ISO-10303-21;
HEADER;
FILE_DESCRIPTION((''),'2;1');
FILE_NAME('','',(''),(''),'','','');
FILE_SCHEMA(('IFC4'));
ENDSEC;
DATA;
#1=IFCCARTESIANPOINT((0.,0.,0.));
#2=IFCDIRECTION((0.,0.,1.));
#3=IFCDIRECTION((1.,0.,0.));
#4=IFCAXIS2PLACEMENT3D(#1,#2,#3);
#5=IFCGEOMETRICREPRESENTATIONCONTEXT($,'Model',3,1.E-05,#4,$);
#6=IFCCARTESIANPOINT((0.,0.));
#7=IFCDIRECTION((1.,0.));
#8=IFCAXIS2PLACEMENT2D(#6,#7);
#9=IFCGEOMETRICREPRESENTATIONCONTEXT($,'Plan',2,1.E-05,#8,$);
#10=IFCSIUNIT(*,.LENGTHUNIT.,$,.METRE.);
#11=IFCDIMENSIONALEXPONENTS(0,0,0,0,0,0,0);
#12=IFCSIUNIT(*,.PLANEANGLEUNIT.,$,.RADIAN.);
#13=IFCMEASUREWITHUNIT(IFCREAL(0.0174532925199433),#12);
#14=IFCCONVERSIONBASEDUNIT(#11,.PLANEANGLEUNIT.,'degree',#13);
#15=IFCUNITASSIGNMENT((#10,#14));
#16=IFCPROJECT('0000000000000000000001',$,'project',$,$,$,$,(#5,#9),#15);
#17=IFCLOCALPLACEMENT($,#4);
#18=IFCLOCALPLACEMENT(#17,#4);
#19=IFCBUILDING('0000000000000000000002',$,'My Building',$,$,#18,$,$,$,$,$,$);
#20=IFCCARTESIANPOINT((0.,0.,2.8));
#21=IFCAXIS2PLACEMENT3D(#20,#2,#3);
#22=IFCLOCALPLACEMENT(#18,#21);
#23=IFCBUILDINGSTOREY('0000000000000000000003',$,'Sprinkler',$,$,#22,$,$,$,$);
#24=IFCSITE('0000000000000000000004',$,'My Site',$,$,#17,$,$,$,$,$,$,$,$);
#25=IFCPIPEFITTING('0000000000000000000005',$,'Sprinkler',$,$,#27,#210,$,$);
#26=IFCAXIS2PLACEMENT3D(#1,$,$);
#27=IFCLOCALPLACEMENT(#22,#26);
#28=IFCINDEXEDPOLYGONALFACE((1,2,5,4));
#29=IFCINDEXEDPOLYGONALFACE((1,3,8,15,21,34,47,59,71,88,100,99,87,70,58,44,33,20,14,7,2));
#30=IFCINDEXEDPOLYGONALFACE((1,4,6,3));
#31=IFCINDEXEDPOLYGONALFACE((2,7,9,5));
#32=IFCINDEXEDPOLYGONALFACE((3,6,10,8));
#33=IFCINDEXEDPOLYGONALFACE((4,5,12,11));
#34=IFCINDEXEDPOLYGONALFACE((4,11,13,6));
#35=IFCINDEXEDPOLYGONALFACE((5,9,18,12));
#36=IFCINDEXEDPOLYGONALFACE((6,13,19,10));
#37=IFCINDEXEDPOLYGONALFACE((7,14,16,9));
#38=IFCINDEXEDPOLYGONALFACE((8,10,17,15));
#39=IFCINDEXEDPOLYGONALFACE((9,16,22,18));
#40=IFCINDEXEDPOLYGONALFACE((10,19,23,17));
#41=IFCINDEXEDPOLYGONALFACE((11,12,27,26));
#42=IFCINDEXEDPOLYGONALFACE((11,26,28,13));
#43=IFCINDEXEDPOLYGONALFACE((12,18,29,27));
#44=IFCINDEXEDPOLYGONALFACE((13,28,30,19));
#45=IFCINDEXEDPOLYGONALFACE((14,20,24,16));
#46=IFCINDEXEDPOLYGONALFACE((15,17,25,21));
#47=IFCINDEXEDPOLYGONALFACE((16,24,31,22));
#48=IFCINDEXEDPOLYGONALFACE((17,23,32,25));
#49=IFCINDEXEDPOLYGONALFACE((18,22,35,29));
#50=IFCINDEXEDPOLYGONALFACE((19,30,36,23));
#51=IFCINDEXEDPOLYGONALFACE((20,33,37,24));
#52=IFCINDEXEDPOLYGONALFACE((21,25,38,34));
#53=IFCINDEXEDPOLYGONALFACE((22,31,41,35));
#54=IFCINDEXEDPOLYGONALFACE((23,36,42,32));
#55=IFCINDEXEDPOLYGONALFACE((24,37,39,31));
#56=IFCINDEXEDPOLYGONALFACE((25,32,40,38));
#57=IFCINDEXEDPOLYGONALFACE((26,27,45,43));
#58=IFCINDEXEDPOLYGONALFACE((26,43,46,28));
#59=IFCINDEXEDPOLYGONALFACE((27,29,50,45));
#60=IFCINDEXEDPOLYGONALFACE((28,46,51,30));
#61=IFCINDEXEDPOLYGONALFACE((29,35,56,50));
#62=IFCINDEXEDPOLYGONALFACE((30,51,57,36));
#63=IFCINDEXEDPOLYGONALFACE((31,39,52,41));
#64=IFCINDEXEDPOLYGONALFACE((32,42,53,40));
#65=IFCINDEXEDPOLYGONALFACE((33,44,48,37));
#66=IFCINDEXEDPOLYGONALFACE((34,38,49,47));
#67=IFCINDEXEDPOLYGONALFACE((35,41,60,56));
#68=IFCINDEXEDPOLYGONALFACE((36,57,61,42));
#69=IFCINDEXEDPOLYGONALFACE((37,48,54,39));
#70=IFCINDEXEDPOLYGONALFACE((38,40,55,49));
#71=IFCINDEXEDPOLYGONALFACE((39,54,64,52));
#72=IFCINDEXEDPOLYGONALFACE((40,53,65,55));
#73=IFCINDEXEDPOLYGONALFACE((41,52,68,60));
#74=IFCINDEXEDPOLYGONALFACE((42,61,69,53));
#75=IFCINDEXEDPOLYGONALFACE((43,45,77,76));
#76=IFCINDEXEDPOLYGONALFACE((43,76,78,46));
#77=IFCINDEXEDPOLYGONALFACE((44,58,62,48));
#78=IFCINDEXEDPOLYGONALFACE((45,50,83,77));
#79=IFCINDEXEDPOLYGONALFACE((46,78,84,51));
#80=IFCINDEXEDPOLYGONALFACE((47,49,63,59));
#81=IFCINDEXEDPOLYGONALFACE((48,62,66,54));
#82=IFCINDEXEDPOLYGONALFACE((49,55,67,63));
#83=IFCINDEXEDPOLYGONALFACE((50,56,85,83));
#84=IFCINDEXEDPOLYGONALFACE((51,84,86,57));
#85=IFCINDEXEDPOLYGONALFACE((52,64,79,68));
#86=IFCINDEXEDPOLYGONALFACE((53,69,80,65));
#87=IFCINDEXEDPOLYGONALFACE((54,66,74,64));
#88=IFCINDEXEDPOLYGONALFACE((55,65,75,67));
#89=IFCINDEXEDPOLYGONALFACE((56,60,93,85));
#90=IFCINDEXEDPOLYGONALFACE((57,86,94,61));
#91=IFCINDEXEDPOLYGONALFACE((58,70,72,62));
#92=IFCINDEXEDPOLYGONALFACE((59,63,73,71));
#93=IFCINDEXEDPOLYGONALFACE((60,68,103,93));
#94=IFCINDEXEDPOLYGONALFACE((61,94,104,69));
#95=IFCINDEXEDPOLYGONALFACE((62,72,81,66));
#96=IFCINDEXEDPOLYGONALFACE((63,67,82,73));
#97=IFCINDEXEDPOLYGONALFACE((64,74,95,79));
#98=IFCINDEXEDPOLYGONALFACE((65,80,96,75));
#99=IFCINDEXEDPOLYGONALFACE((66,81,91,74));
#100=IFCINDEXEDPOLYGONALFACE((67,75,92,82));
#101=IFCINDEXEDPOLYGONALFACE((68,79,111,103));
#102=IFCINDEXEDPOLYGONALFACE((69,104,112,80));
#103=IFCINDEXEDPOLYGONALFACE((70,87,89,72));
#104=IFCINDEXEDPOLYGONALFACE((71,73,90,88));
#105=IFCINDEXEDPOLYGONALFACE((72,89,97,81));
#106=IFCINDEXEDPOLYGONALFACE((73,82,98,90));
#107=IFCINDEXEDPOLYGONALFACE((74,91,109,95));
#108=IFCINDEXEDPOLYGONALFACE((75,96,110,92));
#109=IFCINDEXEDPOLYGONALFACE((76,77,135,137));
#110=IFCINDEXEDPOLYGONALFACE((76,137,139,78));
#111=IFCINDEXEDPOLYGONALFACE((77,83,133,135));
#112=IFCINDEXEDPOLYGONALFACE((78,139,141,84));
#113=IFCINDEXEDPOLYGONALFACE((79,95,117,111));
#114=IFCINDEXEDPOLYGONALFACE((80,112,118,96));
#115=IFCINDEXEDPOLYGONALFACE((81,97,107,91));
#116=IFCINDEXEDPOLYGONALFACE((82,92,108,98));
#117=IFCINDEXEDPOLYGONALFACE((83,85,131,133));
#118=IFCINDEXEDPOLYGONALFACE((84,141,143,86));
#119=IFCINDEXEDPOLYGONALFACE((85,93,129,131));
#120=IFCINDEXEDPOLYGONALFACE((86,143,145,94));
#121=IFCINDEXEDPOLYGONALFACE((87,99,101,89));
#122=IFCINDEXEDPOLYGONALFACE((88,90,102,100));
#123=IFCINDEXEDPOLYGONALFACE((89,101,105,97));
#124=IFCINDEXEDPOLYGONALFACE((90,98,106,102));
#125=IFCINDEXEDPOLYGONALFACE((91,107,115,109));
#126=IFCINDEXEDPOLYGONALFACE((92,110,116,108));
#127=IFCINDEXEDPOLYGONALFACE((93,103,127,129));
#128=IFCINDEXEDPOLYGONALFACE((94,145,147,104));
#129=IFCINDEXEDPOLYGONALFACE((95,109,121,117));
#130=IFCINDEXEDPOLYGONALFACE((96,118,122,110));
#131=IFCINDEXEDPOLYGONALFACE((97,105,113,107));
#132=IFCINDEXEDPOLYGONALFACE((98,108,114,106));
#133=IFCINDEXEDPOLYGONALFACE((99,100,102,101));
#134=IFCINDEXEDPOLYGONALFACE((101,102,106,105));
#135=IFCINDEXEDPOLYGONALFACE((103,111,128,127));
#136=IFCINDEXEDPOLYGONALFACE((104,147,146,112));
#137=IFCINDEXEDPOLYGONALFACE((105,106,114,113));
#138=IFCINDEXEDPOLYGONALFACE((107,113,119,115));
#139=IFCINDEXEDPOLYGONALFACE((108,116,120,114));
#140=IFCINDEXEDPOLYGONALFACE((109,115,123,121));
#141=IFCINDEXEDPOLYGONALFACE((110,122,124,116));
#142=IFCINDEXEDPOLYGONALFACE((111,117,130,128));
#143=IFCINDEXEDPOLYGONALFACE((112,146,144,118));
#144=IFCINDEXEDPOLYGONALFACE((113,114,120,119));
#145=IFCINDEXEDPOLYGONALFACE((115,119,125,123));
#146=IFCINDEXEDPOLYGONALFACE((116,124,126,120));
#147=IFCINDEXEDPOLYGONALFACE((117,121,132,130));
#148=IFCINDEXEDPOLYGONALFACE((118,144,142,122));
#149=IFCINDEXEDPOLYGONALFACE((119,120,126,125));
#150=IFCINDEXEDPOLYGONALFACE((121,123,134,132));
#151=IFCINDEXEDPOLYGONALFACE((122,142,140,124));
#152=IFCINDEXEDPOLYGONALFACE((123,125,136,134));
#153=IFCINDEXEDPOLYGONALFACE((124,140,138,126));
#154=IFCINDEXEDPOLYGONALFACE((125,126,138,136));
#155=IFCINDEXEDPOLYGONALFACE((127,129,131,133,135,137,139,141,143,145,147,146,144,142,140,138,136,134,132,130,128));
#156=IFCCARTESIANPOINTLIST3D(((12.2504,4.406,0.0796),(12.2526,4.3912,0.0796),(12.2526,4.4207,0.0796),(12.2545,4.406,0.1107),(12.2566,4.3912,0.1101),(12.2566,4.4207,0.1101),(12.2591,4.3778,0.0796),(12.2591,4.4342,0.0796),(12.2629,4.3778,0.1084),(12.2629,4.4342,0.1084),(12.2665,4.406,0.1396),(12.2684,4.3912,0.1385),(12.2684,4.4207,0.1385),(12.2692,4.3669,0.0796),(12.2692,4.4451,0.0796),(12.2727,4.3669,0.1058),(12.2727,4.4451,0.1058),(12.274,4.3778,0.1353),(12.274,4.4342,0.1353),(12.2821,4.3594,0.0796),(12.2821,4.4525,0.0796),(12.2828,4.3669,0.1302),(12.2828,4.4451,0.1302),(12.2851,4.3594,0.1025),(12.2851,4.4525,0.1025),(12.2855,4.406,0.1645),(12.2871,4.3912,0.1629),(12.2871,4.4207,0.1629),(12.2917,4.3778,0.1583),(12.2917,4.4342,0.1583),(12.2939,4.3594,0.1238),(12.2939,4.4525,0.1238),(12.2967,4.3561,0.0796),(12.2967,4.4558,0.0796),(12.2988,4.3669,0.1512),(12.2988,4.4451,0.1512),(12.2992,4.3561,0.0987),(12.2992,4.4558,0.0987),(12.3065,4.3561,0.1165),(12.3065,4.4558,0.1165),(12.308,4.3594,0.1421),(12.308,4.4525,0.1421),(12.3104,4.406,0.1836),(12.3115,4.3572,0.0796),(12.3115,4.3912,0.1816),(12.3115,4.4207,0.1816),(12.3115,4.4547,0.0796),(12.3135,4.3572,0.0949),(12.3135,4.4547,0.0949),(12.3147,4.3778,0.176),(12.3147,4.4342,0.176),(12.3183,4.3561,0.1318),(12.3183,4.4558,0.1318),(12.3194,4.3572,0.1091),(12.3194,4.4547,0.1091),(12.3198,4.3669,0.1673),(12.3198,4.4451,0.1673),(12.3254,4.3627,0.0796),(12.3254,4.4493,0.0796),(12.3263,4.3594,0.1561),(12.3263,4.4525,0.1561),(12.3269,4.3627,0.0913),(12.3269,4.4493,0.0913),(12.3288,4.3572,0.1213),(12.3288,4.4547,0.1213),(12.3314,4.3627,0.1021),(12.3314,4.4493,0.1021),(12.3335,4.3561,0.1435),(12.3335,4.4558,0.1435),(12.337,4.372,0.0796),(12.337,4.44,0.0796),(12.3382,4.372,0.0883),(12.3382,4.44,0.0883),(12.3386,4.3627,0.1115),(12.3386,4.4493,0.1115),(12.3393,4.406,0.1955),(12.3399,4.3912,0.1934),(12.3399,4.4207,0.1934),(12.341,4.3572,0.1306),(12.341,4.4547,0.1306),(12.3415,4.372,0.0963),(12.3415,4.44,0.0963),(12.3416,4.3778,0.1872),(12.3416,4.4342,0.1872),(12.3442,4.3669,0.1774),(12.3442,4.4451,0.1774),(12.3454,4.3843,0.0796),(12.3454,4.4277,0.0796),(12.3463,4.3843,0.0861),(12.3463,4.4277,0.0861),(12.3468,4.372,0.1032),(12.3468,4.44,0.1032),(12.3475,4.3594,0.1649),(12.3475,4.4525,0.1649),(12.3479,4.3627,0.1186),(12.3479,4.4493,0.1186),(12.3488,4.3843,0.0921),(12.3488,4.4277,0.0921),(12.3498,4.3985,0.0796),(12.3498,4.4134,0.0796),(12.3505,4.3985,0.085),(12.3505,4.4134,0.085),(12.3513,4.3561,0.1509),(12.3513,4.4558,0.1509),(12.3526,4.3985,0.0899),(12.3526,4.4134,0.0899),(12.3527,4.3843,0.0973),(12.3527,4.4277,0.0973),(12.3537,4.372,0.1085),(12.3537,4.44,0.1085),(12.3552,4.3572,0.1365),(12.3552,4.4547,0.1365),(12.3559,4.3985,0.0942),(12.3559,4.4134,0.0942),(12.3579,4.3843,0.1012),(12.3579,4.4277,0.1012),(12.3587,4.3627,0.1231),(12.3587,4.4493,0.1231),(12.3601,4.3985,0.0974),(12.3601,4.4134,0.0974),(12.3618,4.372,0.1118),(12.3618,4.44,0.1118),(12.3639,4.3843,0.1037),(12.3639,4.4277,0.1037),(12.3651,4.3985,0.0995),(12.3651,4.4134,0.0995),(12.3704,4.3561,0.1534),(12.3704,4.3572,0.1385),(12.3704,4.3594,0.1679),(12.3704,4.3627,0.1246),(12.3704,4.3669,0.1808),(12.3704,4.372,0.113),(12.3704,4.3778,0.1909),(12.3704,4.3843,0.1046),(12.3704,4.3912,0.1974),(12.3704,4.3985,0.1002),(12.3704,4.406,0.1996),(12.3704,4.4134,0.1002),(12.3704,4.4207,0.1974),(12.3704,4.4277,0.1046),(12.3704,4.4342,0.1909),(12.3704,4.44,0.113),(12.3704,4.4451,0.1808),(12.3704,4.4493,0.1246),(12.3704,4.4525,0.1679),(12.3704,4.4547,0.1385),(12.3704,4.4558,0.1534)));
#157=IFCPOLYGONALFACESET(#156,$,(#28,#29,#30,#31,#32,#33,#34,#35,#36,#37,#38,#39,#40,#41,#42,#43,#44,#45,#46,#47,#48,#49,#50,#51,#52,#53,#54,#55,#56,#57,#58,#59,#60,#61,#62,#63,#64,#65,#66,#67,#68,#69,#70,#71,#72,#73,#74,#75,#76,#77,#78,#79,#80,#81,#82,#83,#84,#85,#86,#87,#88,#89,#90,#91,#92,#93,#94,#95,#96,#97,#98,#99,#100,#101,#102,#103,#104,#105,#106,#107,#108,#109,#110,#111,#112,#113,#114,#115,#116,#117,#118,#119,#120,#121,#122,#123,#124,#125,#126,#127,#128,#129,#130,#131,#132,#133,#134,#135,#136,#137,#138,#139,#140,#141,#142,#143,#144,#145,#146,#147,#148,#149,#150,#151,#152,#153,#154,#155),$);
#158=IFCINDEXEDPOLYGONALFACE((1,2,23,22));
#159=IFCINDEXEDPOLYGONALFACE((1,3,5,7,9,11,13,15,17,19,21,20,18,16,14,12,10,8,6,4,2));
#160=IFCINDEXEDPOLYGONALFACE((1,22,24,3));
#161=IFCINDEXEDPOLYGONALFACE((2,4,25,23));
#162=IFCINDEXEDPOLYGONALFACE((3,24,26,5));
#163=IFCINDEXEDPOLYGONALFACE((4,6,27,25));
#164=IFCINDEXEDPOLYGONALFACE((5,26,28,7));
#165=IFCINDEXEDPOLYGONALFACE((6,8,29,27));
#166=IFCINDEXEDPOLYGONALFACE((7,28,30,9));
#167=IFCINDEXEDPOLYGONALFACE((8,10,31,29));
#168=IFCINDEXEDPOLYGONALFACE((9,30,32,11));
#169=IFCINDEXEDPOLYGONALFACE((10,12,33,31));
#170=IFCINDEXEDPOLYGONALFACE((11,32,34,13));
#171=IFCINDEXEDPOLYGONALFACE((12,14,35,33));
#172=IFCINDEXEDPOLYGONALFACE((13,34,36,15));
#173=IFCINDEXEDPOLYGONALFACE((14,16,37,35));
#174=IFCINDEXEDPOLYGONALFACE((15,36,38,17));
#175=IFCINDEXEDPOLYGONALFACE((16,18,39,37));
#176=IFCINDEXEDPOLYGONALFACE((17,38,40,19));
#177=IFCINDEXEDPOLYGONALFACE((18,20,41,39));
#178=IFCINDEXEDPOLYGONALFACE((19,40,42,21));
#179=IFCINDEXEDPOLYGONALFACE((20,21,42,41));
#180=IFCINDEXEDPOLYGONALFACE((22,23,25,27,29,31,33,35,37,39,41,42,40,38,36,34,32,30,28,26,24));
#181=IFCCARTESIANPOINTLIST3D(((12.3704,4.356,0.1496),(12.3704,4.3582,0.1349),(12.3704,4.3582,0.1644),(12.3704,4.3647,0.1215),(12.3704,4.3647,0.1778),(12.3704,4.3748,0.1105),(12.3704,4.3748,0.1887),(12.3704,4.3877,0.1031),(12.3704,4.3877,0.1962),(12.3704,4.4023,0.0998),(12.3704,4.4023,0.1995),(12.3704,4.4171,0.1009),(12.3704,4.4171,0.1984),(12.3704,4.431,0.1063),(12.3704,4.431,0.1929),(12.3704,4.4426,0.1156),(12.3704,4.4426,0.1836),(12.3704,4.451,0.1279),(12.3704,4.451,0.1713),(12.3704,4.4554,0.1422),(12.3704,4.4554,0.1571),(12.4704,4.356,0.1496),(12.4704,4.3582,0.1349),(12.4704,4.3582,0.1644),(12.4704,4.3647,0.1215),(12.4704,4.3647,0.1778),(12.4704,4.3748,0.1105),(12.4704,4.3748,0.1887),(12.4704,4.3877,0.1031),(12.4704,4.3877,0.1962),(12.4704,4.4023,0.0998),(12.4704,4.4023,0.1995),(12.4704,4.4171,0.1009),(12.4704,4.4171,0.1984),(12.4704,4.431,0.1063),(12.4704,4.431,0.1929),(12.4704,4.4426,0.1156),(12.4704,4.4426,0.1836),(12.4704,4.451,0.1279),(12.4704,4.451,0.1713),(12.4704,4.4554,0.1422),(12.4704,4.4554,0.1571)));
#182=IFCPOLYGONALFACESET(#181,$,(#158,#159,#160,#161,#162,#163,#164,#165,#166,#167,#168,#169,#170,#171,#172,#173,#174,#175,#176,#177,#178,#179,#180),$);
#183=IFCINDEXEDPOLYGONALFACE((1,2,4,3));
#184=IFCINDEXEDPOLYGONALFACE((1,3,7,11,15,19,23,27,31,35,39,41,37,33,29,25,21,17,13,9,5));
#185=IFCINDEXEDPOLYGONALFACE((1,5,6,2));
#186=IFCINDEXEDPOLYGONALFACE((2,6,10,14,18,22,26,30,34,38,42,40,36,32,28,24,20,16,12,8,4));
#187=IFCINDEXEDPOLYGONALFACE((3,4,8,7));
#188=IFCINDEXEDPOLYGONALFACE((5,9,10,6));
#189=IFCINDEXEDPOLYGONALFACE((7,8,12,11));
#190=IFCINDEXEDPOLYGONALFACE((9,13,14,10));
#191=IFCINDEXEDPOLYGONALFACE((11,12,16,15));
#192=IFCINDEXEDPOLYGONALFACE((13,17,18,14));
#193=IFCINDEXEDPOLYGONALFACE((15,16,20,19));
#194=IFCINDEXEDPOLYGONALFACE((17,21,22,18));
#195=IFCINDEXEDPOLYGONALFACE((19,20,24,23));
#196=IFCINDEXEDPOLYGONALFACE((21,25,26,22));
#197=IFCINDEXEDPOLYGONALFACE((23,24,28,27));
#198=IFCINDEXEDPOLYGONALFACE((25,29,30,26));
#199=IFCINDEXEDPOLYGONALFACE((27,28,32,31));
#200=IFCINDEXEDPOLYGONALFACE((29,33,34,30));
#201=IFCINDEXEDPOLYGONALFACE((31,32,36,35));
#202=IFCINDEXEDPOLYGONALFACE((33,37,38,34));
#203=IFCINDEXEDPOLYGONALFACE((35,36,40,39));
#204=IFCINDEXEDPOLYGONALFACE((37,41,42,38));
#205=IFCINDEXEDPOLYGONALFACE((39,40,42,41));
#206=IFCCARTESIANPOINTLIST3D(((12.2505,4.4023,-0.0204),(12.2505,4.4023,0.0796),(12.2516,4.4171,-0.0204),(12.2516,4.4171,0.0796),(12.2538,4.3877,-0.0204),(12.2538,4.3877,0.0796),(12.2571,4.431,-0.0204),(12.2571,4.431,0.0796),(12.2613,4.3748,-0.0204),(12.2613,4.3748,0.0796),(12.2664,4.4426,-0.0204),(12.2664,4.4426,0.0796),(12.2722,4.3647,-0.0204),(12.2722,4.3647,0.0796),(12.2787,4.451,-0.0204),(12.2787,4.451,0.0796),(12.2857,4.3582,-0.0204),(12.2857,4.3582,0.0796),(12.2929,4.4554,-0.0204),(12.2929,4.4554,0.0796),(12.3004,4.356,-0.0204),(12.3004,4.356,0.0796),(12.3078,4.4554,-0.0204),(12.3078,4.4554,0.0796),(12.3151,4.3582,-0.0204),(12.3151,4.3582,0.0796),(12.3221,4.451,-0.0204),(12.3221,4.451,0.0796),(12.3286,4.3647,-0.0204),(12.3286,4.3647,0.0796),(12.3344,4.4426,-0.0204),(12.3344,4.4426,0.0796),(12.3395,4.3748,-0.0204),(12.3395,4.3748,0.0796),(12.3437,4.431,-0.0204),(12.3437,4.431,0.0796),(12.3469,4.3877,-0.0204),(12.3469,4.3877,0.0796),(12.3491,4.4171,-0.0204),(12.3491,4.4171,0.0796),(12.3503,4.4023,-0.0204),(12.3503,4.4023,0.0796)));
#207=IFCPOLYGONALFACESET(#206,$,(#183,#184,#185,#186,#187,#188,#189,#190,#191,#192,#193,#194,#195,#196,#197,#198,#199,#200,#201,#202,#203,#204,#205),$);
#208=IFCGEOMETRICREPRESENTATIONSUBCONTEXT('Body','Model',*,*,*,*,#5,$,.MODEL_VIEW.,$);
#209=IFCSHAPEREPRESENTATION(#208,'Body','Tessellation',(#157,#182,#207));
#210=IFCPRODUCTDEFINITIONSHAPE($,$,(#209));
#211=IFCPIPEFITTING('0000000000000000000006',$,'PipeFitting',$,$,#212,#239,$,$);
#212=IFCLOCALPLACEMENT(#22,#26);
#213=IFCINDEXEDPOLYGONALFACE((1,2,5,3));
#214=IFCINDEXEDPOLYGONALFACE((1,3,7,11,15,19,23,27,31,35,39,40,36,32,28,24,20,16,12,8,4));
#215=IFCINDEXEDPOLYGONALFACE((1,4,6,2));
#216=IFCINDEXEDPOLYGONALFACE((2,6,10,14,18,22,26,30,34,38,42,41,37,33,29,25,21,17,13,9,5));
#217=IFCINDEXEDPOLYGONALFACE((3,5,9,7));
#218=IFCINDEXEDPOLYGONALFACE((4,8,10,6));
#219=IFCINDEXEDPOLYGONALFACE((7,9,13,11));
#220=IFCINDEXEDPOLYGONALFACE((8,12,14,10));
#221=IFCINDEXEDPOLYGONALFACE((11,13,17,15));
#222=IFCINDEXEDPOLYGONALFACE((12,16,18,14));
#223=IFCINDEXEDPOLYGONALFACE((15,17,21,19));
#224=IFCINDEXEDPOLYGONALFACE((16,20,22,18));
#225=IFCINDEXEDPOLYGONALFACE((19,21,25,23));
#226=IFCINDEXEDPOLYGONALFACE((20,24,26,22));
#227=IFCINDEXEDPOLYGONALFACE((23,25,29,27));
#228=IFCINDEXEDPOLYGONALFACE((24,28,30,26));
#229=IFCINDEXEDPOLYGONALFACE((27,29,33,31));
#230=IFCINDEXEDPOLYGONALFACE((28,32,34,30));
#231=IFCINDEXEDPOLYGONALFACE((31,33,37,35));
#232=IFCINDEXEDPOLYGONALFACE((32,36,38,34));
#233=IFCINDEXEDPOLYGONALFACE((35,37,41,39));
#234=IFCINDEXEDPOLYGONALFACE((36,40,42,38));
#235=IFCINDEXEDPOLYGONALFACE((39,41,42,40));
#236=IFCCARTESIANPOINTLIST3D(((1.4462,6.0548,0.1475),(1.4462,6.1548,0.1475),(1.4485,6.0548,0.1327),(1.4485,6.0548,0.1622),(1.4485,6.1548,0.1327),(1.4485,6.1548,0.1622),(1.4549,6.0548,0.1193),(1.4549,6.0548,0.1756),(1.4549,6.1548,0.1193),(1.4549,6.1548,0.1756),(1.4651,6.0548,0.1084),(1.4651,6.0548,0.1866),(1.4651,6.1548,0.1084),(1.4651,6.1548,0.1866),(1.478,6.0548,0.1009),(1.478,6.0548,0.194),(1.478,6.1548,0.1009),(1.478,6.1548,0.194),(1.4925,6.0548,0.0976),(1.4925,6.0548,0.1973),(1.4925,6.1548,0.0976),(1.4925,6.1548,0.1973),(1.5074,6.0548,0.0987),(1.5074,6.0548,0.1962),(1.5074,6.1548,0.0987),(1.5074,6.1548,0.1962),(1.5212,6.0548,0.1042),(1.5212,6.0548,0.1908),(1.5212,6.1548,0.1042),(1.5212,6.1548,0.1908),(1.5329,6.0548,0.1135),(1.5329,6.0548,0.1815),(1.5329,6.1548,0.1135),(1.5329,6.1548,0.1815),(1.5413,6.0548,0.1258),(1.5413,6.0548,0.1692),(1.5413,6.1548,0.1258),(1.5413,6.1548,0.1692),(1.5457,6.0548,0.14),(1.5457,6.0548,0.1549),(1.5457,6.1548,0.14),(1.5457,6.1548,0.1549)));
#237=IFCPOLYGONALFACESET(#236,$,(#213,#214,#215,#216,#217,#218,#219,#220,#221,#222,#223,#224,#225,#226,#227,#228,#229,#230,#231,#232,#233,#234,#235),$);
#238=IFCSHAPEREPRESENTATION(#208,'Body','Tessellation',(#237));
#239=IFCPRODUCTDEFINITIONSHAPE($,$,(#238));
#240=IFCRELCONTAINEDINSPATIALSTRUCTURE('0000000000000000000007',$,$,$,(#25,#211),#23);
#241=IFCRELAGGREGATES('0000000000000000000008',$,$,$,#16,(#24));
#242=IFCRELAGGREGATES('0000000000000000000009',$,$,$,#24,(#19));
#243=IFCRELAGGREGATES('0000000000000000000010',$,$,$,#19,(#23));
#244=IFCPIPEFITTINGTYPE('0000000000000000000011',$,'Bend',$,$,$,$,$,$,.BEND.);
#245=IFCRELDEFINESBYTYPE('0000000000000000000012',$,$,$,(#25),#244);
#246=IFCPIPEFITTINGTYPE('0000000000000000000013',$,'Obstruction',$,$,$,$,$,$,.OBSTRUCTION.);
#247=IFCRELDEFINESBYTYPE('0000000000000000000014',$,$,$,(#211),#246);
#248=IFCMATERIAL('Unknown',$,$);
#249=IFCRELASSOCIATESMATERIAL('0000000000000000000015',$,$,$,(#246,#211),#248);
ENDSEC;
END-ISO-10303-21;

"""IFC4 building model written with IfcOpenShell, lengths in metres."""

from ifc_helpers import new_model, entity, si_unit, converted_unit, frame, origin_with_axes, origin_2d_with_axis, place, context, subcontext, project, spatial, circle, extrude, source, transform, mapped, material, material_profile, profile_set, profile_usage, type_object, type_shapes, element, save


model = new_model("IFC4")

# Units and contexts
model_context = context("Model", 3, precision=1e-05, world=origin_with_axes())
plan_context = context("Plan", 2, precision=1e-05, world=origin_2d_with_axis())
body_context = subcontext(model_context, "Body", "Model", "MODEL_VIEW")
ifc_project = project(units=[si_unit("LENGTHUNIT", "METRE"), converted_unit("PLANEANGLEUNIT", "degree", entity("IfcReal", 0.0174532925199433), si_unit("PLANEANGLEUNIT", "RADIAN"), dimensions=[0, 0, 0, 0, 0, 0, 0])], contexts=[model_context, plan_context])

# Site, building, storey
site_placement = place(None, origin_with_axes())
site = spatial("IfcSite", under=ifc_project, at=site_placement, Name="My Site")
building_placement = place(site_placement, origin_with_axes())
building = spatial("IfcBuilding", under=site, at=building_placement, Name="My Building")
storey_placement = place(building_placement, frame((0.0, 0.0, 2.8), z_axis=(0.0, 0.0, 1.0), x_axis=(1.0, 0.0, 0.0)))
storey = spatial("IfcBuildingStorey", under=building, at=storey_placement, Name="Sprinkler")

# Shared definitions
ifc_material = material(Name="Unknown")

# Pipe fittings
pipe_fitting_type_1 = type_object("IfcPipeFittingType", Name="Bend", PredefinedType="BEND")
shared_shape_1 = source(origin_with_axes(), body_context, "Body", "SolidModel", [
    entity("IfcSweptDiskSolid", entity("IfcIndexedPolyCurve", entity("IfcCartesianPointList3D", [[0.0, 0.0, 0.1], [0.0, -0.0205, 0.1495], [0.0, -0.07, 0.17]]), [entity("IfcArcIndex", [1, 2, 3])]), 0.05),
    extrude(circle(Radius=0.05), origin_with_axes(), (0.0, 0.0, 1.0), 0.1),
    extrude(circle(Radius=0.05), frame((0.0, -0.07, 0.17), z_axis=(0.0, -1.0, 0.0), x_axis=(1.0, 0.0, 0.0)), (0.0, 0.0, 1.0), 0.1),
])
type_shapes(pipe_fitting_type_1, [shared_shape_1])
for number, where, z_axis, x_axis, name in (
    (1, (12.4704, 4.406, 0.1496), (-1.0, -0.000001, 0.0), (0.000001, -1.0, 0.0), "Sprinkler"),
):
    element("IfcPipeFitting", number, at=place(storey_placement, frame(where, z_axis=z_axis, x_axis=x_axis)), inside=storey, type_object=pipe_fitting_type_1, Name=name, context=body_context, shape_type="MappedRepresentation", body=[
        mapped(shared_shape_1, transform((0.0, 0.0, 0.0), x_axis=(1.0, 0.0, 0.0), y_axis=(0.0, 1.0, 0.0), z_axis=(0.0, 0.0, 1.0), scale=1.0)),
    ])
ifc_material_profile_1 = material_profile(ifc_material, circle(Radius=0.05))
ifc_profile_set_1 = profile_set([ifc_material_profile_1])
ifc_profile_usage_1 = profile_usage(ifc_profile_set_1, cardinal=8)
pipe_fitting_type_2 = type_object("IfcPipeFittingType", Name="Obstruction", PredefinedType="OBSTRUCTION", material=ifc_profile_set_1)
pipe_fitting_1_placement = place(storey_placement, frame((1.4962, 6.0548, 0.1975), z_axis=(0.0, 1.0, -0.000008), x_axis=(-1.0, 0.0, 0.0)))
element("IfcPipeFitting", 2, at=pipe_fitting_1_placement, inside=storey, type_object=pipe_fitting_type_2, material=ifc_profile_usage_1, Name="PipeFitting", context=body_context, shape_type="SweptSolid", body=[
    extrude(circle(Radius=0.05), frame((0.0, -0.05, 0.0), z_axis=(0.0, 0.0, 1.0), x_axis=(1.0, 0.0, 0.0)), (0.0, 0.0, 1.0), 0.1),
])

save(model, "model.ifc")
